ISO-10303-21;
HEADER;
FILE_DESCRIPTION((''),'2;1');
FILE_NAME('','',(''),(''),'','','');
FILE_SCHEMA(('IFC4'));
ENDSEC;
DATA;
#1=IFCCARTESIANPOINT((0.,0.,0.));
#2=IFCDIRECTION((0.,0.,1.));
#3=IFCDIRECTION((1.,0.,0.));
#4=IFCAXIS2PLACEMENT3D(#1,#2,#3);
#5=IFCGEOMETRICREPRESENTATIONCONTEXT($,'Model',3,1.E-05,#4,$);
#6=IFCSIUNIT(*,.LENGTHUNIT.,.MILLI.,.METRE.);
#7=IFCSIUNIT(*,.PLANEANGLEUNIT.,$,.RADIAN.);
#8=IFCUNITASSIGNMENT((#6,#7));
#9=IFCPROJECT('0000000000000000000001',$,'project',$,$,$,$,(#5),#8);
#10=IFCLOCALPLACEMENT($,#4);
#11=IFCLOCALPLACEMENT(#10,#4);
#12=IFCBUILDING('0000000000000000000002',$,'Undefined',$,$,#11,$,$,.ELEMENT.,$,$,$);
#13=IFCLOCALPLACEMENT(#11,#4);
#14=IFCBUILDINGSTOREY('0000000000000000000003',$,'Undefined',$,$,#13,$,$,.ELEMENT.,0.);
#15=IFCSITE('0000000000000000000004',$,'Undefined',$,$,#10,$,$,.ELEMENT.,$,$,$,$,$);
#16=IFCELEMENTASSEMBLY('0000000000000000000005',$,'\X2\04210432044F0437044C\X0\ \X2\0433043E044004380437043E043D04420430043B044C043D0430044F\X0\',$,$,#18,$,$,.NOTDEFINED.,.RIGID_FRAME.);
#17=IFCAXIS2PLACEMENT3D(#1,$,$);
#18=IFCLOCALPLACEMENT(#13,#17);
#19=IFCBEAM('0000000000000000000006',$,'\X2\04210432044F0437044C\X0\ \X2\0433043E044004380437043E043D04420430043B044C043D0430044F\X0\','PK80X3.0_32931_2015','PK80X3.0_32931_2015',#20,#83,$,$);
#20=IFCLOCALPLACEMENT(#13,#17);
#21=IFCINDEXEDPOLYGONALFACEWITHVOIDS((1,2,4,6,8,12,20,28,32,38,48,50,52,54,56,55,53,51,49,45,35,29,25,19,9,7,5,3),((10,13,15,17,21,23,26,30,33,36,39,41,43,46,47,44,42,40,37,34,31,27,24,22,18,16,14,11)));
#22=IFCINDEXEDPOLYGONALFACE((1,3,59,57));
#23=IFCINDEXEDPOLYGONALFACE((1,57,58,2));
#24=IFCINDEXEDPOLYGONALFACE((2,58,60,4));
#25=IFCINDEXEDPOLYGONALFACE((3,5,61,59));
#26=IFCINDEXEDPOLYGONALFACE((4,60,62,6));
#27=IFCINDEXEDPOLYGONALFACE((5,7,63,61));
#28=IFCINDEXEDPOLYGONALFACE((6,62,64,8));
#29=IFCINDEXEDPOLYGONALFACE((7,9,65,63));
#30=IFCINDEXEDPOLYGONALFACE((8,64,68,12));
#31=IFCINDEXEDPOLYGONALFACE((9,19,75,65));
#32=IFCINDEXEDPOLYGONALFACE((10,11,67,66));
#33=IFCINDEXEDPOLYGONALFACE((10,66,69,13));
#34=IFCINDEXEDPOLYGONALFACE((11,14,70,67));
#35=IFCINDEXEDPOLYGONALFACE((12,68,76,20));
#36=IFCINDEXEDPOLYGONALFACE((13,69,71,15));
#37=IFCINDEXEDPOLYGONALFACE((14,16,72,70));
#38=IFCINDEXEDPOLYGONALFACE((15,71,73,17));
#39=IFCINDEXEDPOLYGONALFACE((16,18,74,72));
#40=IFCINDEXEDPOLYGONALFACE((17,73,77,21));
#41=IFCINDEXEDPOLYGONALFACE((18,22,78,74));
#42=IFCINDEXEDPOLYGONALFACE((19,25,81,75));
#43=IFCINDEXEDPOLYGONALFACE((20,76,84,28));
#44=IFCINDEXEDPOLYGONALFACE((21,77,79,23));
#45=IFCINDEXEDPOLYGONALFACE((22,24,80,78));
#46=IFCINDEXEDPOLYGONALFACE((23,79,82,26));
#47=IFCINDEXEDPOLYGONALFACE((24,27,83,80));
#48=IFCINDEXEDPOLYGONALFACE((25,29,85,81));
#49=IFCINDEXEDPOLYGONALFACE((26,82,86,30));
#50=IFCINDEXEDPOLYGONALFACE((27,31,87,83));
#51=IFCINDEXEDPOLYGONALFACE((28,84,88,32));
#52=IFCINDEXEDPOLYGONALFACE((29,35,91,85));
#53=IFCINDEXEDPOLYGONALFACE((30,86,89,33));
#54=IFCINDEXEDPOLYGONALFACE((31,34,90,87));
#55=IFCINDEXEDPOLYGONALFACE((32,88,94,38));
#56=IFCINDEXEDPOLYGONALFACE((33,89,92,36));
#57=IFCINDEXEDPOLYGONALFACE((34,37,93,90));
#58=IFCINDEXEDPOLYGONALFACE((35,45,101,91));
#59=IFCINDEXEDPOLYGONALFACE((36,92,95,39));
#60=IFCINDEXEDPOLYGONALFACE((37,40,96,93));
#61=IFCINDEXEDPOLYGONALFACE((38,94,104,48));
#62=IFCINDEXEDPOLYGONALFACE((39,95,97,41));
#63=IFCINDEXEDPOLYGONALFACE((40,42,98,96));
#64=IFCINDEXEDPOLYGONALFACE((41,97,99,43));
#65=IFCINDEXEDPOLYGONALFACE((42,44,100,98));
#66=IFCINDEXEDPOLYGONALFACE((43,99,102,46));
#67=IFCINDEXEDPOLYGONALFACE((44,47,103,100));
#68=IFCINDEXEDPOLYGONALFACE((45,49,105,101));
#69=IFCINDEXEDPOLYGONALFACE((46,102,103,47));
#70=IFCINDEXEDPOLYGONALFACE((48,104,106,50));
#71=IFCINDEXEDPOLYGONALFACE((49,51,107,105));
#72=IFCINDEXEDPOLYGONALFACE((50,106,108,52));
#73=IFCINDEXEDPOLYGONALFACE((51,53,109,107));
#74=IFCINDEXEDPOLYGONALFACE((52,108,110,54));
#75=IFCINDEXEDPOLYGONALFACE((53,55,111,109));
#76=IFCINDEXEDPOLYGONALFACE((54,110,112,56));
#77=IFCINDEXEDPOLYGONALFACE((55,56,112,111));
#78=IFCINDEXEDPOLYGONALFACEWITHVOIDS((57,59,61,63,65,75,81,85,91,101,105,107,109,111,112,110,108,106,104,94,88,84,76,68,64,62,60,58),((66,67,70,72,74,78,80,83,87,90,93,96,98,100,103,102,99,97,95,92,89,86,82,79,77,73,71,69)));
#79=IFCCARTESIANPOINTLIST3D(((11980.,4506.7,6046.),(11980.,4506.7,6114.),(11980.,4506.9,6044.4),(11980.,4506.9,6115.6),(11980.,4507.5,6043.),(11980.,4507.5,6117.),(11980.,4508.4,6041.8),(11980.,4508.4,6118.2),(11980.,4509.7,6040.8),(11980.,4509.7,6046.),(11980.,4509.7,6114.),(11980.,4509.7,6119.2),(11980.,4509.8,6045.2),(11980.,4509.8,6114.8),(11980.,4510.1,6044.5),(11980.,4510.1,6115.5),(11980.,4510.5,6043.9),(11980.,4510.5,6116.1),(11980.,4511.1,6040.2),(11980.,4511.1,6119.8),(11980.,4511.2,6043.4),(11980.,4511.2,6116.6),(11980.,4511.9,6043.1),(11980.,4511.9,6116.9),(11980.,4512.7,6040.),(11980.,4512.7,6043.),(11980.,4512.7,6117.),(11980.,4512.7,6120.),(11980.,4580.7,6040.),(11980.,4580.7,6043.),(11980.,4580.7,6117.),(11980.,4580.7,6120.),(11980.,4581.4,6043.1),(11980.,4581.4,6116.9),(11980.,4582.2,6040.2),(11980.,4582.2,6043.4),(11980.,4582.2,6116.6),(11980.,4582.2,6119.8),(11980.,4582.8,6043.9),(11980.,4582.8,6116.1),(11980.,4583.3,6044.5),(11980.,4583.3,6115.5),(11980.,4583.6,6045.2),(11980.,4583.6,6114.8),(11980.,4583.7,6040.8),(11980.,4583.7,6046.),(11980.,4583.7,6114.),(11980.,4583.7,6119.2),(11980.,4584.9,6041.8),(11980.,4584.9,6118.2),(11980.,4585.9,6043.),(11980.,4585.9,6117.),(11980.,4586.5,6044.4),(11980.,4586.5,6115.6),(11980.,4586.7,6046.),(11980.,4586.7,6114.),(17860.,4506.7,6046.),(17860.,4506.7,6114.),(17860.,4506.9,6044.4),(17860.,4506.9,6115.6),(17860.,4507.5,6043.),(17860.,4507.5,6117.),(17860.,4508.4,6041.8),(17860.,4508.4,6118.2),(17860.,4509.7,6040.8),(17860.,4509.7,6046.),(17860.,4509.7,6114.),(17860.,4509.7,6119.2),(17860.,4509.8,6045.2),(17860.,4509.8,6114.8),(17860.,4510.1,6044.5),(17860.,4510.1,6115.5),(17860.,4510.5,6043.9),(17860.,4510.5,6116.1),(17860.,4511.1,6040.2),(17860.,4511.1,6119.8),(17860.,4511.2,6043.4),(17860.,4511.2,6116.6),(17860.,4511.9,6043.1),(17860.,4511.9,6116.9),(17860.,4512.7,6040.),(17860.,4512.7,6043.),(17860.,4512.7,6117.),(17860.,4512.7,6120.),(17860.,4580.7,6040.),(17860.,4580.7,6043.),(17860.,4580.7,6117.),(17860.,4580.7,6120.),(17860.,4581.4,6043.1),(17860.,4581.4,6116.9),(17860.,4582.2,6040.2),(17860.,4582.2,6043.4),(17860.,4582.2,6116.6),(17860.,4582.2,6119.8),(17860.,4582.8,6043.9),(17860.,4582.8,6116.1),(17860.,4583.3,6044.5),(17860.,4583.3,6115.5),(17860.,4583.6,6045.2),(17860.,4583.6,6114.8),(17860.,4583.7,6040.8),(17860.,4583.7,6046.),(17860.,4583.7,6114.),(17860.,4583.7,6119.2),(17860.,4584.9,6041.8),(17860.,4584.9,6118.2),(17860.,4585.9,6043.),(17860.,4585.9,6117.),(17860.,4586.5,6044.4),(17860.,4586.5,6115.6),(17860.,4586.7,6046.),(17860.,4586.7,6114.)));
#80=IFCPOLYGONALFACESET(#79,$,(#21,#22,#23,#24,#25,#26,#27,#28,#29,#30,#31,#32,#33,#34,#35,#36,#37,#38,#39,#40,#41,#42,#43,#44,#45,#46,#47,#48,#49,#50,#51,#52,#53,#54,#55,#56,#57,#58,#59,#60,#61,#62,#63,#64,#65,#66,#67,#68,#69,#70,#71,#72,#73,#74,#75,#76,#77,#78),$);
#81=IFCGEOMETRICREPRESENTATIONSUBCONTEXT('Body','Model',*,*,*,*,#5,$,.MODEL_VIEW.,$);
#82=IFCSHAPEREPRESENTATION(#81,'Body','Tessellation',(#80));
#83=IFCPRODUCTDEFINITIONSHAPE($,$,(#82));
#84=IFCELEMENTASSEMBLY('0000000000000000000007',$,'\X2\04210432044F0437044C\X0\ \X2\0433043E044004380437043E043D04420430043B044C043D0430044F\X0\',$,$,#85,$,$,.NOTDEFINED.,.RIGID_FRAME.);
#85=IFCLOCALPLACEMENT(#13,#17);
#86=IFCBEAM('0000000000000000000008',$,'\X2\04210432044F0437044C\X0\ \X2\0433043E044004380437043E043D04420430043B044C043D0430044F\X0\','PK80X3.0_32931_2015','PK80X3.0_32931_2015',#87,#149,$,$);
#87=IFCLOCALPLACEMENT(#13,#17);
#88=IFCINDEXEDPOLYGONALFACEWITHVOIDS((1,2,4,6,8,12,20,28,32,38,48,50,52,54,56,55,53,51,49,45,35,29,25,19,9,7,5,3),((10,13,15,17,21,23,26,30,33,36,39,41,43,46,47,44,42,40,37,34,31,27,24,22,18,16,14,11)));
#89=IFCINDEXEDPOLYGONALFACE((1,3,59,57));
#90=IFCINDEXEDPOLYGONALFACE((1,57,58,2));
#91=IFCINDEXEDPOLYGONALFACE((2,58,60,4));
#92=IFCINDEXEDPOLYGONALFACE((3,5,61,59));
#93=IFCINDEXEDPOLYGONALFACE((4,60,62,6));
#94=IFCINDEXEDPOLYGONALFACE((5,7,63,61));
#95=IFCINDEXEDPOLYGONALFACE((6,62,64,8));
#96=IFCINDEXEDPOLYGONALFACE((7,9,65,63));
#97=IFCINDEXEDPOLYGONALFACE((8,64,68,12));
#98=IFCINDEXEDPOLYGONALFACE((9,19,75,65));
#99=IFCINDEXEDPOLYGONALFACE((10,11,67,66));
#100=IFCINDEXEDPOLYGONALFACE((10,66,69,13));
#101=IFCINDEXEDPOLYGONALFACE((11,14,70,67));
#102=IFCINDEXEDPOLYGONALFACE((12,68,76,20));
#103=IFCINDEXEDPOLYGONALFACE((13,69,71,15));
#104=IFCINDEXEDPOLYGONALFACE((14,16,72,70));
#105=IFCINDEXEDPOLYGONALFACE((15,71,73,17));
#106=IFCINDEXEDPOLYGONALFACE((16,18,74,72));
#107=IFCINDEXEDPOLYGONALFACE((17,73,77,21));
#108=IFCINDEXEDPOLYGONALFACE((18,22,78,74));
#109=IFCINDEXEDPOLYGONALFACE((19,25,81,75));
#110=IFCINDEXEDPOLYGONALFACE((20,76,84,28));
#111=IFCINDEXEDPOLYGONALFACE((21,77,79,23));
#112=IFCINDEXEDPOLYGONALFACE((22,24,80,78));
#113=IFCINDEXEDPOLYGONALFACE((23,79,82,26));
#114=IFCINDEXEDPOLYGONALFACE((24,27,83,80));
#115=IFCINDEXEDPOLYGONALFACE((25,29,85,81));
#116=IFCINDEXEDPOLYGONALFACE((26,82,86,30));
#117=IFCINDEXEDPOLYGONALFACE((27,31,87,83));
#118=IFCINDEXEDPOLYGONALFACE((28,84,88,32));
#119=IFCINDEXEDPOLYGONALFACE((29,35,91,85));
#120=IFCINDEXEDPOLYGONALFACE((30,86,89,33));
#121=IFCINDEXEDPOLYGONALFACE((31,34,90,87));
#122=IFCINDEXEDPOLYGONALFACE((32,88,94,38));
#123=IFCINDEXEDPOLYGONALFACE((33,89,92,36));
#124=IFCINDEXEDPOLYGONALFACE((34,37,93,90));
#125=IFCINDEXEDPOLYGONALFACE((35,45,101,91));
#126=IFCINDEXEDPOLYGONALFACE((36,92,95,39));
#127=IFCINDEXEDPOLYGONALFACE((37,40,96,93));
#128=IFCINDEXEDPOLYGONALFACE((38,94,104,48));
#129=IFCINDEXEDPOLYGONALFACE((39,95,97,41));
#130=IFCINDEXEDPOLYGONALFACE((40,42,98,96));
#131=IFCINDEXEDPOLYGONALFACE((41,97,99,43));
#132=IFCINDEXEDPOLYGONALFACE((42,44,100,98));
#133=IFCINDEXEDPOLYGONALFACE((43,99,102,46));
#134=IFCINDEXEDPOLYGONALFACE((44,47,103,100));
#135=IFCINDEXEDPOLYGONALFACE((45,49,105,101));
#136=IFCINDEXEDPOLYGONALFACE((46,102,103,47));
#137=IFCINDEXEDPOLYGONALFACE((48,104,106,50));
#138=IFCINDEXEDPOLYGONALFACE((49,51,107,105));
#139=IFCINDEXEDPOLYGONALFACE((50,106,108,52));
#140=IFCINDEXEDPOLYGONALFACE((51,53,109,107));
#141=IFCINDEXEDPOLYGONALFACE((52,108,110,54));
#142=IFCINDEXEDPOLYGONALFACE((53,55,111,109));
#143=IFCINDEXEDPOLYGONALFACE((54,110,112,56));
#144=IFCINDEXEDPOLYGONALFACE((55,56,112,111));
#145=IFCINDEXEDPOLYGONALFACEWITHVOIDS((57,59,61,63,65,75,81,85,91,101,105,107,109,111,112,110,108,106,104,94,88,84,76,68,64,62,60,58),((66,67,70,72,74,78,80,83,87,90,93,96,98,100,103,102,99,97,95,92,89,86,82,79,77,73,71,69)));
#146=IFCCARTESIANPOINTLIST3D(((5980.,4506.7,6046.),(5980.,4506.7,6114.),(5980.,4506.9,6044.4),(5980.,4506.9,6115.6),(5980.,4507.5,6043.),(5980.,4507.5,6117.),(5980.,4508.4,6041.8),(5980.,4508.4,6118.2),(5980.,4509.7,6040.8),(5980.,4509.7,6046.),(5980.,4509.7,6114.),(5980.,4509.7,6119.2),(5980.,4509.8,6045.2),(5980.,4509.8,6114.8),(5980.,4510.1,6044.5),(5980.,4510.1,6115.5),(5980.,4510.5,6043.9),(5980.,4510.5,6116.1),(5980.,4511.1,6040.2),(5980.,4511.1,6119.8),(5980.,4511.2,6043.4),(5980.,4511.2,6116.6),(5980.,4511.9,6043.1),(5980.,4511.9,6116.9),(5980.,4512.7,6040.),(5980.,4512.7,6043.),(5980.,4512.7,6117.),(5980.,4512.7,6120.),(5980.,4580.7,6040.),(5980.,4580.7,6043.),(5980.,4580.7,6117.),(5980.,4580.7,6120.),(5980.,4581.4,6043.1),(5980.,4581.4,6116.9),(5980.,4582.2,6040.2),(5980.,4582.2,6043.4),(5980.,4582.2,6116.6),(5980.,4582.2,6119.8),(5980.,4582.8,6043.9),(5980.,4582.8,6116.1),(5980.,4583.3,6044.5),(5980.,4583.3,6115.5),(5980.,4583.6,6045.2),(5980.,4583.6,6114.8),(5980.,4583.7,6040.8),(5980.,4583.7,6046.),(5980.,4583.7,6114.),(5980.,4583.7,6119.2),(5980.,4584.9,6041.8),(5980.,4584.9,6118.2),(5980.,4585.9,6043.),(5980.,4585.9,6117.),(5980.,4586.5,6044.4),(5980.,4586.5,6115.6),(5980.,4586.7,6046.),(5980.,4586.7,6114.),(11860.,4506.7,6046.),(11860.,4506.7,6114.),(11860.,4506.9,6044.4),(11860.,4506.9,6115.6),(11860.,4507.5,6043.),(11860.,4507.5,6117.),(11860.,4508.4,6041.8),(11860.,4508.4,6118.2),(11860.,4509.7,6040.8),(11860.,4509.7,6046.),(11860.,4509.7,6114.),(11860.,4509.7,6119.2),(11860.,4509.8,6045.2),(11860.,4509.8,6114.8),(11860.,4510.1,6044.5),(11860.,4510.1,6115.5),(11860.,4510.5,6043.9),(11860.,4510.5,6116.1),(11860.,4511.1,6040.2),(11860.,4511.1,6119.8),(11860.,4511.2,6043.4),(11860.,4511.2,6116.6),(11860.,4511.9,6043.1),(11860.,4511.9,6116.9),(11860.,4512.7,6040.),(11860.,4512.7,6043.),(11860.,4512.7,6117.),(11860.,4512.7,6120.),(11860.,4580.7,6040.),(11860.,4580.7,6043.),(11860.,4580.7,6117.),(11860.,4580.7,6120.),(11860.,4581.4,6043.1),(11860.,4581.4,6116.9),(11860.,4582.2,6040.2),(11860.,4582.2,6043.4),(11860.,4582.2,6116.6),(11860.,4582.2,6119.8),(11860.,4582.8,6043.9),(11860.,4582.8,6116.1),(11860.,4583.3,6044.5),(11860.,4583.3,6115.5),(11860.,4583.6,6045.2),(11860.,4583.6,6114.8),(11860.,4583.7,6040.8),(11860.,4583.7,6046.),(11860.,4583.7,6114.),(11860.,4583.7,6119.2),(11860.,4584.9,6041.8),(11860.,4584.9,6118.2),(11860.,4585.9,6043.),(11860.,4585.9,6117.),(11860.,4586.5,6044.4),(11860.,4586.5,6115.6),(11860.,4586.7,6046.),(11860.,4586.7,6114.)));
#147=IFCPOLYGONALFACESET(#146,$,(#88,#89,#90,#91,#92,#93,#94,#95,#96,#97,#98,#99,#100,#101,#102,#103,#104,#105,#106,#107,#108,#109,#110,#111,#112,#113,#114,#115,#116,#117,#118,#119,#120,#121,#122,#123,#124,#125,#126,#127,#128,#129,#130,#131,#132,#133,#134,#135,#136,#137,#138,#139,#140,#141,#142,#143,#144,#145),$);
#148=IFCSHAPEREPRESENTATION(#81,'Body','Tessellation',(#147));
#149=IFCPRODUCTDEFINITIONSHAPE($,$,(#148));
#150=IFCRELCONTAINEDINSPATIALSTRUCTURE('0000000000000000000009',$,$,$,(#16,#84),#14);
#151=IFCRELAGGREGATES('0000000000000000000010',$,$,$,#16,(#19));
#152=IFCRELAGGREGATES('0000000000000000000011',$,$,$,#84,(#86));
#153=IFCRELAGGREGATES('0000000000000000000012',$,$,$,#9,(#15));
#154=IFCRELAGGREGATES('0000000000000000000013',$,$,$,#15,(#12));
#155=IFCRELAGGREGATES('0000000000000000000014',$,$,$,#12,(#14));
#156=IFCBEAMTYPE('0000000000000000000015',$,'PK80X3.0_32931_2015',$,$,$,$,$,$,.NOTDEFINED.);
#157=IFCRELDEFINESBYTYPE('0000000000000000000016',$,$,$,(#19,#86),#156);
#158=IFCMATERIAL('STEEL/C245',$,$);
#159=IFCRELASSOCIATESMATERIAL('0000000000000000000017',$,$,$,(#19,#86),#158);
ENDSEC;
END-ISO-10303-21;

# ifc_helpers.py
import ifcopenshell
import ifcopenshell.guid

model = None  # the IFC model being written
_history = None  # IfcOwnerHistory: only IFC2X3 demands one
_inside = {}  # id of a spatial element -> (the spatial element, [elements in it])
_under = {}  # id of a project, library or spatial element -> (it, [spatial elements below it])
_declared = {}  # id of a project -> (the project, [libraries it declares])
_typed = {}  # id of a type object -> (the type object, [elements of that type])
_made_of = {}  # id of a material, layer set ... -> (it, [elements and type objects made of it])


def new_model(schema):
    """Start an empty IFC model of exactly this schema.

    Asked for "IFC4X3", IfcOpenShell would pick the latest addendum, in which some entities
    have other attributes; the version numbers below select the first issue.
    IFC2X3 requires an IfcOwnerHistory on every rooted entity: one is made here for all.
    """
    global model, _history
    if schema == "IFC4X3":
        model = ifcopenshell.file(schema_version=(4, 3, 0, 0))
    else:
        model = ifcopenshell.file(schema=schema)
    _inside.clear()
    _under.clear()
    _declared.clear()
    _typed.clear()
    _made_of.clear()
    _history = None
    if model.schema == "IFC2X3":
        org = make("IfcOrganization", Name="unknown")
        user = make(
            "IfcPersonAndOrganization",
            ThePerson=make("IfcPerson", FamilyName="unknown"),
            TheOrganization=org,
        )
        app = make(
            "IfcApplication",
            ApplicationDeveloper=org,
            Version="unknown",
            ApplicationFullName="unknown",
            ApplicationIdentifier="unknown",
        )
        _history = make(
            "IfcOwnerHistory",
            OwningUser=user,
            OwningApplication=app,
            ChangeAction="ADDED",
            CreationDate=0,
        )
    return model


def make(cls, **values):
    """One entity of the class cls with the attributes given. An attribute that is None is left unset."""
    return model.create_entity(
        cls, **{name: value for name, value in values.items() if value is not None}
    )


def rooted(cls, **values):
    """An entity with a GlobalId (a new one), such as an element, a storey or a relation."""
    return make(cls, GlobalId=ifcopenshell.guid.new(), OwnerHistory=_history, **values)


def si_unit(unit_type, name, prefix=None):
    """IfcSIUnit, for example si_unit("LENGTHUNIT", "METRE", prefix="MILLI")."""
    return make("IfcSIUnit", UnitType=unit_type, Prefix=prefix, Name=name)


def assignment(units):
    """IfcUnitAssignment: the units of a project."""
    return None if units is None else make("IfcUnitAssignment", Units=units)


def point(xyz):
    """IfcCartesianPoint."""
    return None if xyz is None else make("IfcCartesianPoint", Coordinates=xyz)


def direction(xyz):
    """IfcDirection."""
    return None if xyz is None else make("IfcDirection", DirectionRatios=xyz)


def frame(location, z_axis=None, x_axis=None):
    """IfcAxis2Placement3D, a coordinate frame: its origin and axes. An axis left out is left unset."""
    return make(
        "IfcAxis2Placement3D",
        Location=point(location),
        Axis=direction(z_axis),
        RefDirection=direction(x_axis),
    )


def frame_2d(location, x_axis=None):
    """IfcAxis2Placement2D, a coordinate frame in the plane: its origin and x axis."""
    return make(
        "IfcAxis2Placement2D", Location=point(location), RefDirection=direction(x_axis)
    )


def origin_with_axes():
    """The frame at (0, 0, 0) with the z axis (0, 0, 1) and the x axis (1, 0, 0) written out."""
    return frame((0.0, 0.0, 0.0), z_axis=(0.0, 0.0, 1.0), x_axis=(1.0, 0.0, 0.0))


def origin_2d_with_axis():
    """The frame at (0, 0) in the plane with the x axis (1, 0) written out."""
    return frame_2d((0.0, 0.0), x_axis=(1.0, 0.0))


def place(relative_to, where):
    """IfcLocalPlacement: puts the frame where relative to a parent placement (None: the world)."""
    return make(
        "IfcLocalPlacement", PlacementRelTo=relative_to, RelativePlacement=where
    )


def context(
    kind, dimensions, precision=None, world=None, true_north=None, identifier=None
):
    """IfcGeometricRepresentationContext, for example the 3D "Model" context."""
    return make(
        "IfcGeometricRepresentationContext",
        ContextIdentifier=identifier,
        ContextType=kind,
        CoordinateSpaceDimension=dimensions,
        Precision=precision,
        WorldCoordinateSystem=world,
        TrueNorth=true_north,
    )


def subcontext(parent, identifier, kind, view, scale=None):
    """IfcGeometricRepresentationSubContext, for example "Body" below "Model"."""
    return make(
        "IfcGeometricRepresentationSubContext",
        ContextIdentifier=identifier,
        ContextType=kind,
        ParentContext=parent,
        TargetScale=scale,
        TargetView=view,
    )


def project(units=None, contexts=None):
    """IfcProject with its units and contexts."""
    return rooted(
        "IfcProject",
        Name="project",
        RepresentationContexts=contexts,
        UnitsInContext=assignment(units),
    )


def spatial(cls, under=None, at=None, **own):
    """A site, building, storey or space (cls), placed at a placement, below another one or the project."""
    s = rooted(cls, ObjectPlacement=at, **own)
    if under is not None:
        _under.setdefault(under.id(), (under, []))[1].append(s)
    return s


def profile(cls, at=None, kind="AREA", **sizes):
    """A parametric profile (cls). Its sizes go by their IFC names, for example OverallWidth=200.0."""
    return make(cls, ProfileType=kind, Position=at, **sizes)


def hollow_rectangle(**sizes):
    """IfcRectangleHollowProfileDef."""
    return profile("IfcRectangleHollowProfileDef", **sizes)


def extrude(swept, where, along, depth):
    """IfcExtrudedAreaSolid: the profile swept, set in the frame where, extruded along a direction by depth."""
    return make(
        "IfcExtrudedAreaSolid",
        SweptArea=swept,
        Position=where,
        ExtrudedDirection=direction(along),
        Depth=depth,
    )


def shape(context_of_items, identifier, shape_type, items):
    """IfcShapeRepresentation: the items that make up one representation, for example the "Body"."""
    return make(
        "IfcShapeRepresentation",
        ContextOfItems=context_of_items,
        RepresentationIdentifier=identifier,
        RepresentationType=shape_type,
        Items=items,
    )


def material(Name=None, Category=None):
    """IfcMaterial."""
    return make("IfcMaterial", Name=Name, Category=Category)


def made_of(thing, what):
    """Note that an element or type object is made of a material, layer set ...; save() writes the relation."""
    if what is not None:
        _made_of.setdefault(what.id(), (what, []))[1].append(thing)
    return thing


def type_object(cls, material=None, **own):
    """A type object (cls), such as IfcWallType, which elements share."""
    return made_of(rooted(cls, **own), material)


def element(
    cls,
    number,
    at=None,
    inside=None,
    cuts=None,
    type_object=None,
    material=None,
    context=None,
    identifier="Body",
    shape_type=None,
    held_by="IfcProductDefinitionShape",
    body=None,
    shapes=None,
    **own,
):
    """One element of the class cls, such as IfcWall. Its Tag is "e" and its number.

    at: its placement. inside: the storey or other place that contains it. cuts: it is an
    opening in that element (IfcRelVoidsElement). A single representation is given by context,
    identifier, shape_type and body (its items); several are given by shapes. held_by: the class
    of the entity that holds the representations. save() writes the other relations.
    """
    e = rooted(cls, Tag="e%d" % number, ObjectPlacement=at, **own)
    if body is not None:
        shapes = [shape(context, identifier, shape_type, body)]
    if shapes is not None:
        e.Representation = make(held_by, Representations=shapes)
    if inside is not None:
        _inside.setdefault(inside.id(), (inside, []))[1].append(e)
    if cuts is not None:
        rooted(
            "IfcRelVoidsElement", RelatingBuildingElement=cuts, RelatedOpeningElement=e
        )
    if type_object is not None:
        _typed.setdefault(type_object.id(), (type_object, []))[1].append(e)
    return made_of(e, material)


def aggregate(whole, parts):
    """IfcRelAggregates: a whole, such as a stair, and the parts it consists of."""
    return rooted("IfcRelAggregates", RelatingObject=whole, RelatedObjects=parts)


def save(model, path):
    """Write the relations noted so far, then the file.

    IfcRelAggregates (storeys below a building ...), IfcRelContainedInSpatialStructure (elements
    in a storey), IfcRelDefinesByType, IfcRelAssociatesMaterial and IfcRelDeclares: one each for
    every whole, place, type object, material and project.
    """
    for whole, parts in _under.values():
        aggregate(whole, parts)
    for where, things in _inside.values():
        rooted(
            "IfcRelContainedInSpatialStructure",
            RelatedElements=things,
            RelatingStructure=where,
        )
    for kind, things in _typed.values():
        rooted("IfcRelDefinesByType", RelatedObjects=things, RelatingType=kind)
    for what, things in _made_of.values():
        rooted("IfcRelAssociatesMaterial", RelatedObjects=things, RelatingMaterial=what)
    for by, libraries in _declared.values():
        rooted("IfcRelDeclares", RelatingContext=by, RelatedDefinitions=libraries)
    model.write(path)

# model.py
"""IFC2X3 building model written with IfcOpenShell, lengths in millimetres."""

from ifc_helpers import new_model, si_unit, frame, origin_with_axes, origin_2d_with_axis, place, context, subcontext, project, spatial, hollow_rectangle, extrude, material, type_object, element, aggregate, save


model = new_model("IFC2X3")

# Units and contexts
model_context = context("Model", 3, precision=1e-05, world=origin_with_axes())
body_context = subcontext(model_context, "Body", "Model", "MODEL_VIEW")
ifc_project = project(units=[si_unit("LENGTHUNIT", "METRE", prefix="MILLI"), si_unit("PLANEANGLEUNIT", "RADIAN")], contexts=[model_context])

# Site, building, storey
site_placement = place(None, origin_with_axes())
site = spatial("IfcSite", under=ifc_project, at=site_placement, Name="Undefined", CompositionType="ELEMENT")
building_placement = place(site_placement, origin_with_axes())
building = spatial("IfcBuilding", under=site, at=building_placement, Name="Undefined", CompositionType="ELEMENT")
storey_placement = place(building_placement, origin_with_axes())
storey = spatial("IfcBuildingStorey", under=building, at=storey_placement, Name="Undefined", CompositionType="ELEMENT", Elevation=0.0)

# Shared definitions
ifc_material = material(Name="STEEL/C245")

# Element assemblies, beams
assembly_1_placement = place(storey_placement, origin_with_axes())
assembly_1 = element("IfcElementAssembly", 1, at=assembly_1_placement, inside=storey, Name="Связь горизонтальная", AssemblyPlace="NOTDEFINED", PredefinedType="RIGID_FRAME")
beam_type_1 = type_object("IfcBeamType", Name="PK80X3.0_32931_2015", PredefinedType="NOTDEFINED")
beam_1_placement = place(assembly_1_placement, frame((11980.0, 4546.7, 6080.0), z_axis=(0.0, 0.0, 1.0), x_axis=(1.0, 0.0, 0.0)))
beam_1 = element("IfcBeam", 2, at=beam_1_placement, type_object=beam_type_1, material=ifc_material, Name="Связь горизонтальная", Description="PK80X3.0_32931_2015", ObjectType="PK80X3.0_32931_2015", context=body_context, shape_type="SweptSolid", body=[
    extrude(hollow_rectangle(XDim=80.0, YDim=80.0, WallThickness=3.0, InnerFilletRadius=3.0, OuterFilletRadius=6.0, at=origin_2d_with_axis()), frame((5880.0, 0.0, 0.0), z_axis=(-1.0, 0.0, 0.0), x_axis=(0.0, -1.0, 0.0)), (0.0, 0.0, 1.0), 5880.0),
])
aggregate(assembly_1, [beam_1])
assembly_2_placement = place(storey_placement, origin_with_axes())
assembly_2 = element("IfcElementAssembly", 3, at=assembly_2_placement, inside=storey, Name="Связь горизонтальная", AssemblyPlace="NOTDEFINED", PredefinedType="RIGID_FRAME")
beam_2_placement = place(assembly_2_placement, frame((5980.0, 4546.7, 6080.0), z_axis=(0.0, 0.0, 1.0), x_axis=(1.0, 0.0, 0.0)))
beam_2 = element("IfcBeam", 4, at=beam_2_placement, type_object=beam_type_1, material=ifc_material, Name="Связь горизонтальная", Description="PK80X3.0_32931_2015", ObjectType="PK80X3.0_32931_2015", context=body_context, shape_type="SweptSolid", body=[
    extrude(hollow_rectangle(XDim=80.0, YDim=80.0, WallThickness=3.0, InnerFilletRadius=3.0, OuterFilletRadius=6.0, at=origin_2d_with_axis()), frame((5880.0, 0.0, 0.0), z_axis=(-1.0, 0.0, 0.0), x_axis=(0.0, -1.0, 0.0)), (0.0, 0.0, 1.0), 5880.0),
])
aggregate(assembly_2, [beam_2])

save(model, "model.ifc")
